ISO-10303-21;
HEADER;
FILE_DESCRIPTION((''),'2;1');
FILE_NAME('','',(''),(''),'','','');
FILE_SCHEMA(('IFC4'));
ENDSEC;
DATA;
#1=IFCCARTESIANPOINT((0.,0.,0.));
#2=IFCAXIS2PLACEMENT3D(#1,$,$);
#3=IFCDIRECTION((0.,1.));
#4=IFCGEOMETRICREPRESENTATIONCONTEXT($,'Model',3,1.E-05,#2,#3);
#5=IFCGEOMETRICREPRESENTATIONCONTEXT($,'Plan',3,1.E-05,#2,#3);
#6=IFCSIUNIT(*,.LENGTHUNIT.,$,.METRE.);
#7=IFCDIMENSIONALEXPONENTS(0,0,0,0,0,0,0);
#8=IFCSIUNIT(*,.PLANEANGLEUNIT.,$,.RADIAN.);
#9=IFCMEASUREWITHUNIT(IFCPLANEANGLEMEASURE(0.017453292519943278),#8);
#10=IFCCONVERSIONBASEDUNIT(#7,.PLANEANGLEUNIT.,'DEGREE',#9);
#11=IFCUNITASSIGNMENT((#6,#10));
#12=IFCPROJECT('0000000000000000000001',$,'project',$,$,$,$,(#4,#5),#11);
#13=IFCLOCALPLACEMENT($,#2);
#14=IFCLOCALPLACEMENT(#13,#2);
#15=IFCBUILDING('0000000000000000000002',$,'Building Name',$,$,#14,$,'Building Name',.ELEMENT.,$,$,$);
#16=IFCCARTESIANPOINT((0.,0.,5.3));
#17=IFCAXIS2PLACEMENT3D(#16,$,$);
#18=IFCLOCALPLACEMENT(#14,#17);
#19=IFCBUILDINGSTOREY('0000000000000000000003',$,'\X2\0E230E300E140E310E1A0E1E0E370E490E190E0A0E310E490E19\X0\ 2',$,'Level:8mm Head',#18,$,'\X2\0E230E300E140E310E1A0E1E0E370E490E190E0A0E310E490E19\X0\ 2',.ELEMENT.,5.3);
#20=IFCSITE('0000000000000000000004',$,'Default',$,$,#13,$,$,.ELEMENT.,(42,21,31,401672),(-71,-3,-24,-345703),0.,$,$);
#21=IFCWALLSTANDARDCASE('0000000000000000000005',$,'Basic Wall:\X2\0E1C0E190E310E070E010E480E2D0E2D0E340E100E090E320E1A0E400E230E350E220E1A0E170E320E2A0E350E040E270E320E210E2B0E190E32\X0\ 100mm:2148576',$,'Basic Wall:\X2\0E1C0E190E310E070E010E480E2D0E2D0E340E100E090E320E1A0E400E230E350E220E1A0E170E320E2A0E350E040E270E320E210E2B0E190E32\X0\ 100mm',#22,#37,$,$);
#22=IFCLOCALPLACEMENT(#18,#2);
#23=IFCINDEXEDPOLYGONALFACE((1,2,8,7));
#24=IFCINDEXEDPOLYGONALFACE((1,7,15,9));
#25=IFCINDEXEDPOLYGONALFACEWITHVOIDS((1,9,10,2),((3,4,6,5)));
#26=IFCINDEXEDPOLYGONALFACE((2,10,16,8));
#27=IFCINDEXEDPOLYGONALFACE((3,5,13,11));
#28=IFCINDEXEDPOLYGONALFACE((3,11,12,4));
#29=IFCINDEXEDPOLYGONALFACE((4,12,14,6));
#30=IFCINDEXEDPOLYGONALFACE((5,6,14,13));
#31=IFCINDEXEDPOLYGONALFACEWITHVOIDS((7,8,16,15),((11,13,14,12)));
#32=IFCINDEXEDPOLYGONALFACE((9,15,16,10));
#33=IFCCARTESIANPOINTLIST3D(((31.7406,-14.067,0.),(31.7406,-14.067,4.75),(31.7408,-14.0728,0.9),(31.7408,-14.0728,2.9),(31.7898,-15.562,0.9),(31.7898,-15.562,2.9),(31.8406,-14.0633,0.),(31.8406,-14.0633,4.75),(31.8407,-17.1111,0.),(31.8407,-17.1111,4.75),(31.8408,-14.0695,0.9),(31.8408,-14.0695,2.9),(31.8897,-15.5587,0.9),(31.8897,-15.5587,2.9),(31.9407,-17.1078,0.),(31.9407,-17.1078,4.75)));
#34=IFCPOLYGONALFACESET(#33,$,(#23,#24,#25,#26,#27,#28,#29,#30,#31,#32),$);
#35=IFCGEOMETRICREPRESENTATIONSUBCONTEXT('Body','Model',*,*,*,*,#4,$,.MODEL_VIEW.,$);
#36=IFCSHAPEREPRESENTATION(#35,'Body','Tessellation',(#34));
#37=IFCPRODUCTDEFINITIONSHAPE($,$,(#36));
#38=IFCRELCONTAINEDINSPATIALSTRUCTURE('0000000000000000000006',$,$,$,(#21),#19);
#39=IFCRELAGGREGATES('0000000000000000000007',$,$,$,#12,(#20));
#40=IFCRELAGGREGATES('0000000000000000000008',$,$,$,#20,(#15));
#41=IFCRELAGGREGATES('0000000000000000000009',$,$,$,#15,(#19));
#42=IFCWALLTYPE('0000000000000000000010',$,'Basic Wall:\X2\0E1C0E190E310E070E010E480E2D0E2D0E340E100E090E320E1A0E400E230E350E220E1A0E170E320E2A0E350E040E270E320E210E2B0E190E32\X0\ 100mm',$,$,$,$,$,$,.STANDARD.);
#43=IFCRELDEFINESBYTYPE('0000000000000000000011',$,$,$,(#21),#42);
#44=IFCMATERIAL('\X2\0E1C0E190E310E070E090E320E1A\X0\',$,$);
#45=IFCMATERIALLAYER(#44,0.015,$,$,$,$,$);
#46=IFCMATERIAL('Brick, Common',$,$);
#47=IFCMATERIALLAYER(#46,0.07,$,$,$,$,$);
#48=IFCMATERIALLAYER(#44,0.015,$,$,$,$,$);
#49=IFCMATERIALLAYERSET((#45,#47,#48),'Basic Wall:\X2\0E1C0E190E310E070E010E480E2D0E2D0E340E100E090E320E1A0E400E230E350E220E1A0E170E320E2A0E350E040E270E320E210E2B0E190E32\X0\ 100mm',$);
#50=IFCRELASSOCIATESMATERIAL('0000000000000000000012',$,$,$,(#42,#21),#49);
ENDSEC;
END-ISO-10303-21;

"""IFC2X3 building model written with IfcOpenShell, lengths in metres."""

from ifc_helpers import new_model, entity, si_unit, converted_unit, direction, frame, frame_2d, origin, place, context, subcontext, project, spatial, polyline, rectangle, outline, extrude, material, layer, layer_set, layer_usage, type_object, element, save


model = new_model("IFC2X3")

# Units and contexts
model_context = context("Model", 3, precision=1e-05, world=origin(), true_north=direction((0.0, 1.0)))
plan_context = context("Plan", 3, precision=1e-05, world=origin(), true_north=direction((0.0, 1.0)))
body_context = subcontext(model_context, "Body", "Model", "MODEL_VIEW")
ifc_project = project(units=[si_unit("LENGTHUNIT", "METRE"), converted_unit("PLANEANGLEUNIT", "DEGREE", entity("IfcPlaneAngleMeasure", 0.017453292519943278), si_unit("PLANEANGLEUNIT", "RADIAN"), dimensions=[0, 0, 0, 0, 0, 0, 0])], contexts=[model_context, plan_context])

# Site, building, storey
site_placement = place(None, origin())
site = spatial("IfcSite", under=ifc_project, at=site_placement, Name="Default", CompositionType="ELEMENT", RefLatitude=(42, 21, 31, 401672), RefLongitude=(-71, -3, -24, -345703), RefElevation=0.0)
building_placement = place(site_placement, origin())
building = spatial("IfcBuilding", under=site, at=building_placement, Name="Building Name", LongName="Building Name", CompositionType="ELEMENT")
storey_placement = place(building_placement, frame((0.0, 0.0, 5.3)))
storey = spatial("IfcBuildingStorey", under=building, at=storey_placement, Name="ระดับพื้นชั้น 2", ObjectType="Level:8mm Head", LongName="ระดับพื้นชั้น 2", CompositionType="ELEMENT", Elevation=5.3)

# Wall, opening
ifc_material_1 = material(Name="ผนังฉาบ")
ifc_layer_1 = layer(ifc_material_1, 0.015)
ifc_material_2 = material(Name="Brick, Common")
ifc_layer_2 = layer(ifc_material_2, 0.07)
ifc_layer_3 = layer(ifc_material_1, 0.015)
ifc_layer_set = layer_set([ifc_layer_1, ifc_layer_2, ifc_layer_3], Name="Basic Wall:ผนังก่ออิฐฉาบเรียบทาสีความหนา 100mm")
ifc_layer_usage = layer_usage(ifc_layer_set, "AXIS2", "NEGATIVE", 0.05)
wall_type = type_object("IfcWallType", Name="Basic Wall:ผนังก่ออิฐฉาบเรียบทาสีความหนา 100mm", PredefinedType="STANDARD", material=ifc_layer_set)
wall_placement = place(storey_placement, frame((31.7906, -14.0649, 0.0), z_axis=(0.0, 0.0, 1.0), x_axis=(0.032862, -0.99946, 0.0)))
wall = element("IfcWallStandardCase", 1, at=wall_placement, inside=storey, type_object=wall_type, material=ifc_layer_usage, Name="Basic Wall:ผนังก่ออิฐฉาบเรียบทาสีความหนา 100mm:2148576", ObjectType="Basic Wall:ผนังก่ออิฐฉาบเรียบทาสีความหนา 100mm", context=body_context, shape_type="SweptSolid", body=[
    extrude(outline(polyline([(3.0462, -0.05), (3.0462, 0.05), (0.0, 0.05), (0.0004, -0.05), (3.0462, -0.05)])), origin(), (0.0, 0.0, 1.0), 4.75),
])
opening_placement = place(wall_placement, frame((0.0062, -0.05, 0.9)))
element("IfcOpeningElement", 2, at=opening_placement, cuts=wall, ObjectType="Opening", context=body_context, shape_type="SweptSolid", body=[
    extrude(rectangle(XDim=2.0, YDim=1.49, at=frame_2d((1.0, 0.745), x_axis=(1.0, 0.0))), frame((0.0, 0.0, 0.0), z_axis=(0.0, 1.0, 0.0), x_axis=(0.0, 0.0, 1.0)), (0.0, 0.0, 1.0), 0.1),
])

save(model, "model.ifc")
